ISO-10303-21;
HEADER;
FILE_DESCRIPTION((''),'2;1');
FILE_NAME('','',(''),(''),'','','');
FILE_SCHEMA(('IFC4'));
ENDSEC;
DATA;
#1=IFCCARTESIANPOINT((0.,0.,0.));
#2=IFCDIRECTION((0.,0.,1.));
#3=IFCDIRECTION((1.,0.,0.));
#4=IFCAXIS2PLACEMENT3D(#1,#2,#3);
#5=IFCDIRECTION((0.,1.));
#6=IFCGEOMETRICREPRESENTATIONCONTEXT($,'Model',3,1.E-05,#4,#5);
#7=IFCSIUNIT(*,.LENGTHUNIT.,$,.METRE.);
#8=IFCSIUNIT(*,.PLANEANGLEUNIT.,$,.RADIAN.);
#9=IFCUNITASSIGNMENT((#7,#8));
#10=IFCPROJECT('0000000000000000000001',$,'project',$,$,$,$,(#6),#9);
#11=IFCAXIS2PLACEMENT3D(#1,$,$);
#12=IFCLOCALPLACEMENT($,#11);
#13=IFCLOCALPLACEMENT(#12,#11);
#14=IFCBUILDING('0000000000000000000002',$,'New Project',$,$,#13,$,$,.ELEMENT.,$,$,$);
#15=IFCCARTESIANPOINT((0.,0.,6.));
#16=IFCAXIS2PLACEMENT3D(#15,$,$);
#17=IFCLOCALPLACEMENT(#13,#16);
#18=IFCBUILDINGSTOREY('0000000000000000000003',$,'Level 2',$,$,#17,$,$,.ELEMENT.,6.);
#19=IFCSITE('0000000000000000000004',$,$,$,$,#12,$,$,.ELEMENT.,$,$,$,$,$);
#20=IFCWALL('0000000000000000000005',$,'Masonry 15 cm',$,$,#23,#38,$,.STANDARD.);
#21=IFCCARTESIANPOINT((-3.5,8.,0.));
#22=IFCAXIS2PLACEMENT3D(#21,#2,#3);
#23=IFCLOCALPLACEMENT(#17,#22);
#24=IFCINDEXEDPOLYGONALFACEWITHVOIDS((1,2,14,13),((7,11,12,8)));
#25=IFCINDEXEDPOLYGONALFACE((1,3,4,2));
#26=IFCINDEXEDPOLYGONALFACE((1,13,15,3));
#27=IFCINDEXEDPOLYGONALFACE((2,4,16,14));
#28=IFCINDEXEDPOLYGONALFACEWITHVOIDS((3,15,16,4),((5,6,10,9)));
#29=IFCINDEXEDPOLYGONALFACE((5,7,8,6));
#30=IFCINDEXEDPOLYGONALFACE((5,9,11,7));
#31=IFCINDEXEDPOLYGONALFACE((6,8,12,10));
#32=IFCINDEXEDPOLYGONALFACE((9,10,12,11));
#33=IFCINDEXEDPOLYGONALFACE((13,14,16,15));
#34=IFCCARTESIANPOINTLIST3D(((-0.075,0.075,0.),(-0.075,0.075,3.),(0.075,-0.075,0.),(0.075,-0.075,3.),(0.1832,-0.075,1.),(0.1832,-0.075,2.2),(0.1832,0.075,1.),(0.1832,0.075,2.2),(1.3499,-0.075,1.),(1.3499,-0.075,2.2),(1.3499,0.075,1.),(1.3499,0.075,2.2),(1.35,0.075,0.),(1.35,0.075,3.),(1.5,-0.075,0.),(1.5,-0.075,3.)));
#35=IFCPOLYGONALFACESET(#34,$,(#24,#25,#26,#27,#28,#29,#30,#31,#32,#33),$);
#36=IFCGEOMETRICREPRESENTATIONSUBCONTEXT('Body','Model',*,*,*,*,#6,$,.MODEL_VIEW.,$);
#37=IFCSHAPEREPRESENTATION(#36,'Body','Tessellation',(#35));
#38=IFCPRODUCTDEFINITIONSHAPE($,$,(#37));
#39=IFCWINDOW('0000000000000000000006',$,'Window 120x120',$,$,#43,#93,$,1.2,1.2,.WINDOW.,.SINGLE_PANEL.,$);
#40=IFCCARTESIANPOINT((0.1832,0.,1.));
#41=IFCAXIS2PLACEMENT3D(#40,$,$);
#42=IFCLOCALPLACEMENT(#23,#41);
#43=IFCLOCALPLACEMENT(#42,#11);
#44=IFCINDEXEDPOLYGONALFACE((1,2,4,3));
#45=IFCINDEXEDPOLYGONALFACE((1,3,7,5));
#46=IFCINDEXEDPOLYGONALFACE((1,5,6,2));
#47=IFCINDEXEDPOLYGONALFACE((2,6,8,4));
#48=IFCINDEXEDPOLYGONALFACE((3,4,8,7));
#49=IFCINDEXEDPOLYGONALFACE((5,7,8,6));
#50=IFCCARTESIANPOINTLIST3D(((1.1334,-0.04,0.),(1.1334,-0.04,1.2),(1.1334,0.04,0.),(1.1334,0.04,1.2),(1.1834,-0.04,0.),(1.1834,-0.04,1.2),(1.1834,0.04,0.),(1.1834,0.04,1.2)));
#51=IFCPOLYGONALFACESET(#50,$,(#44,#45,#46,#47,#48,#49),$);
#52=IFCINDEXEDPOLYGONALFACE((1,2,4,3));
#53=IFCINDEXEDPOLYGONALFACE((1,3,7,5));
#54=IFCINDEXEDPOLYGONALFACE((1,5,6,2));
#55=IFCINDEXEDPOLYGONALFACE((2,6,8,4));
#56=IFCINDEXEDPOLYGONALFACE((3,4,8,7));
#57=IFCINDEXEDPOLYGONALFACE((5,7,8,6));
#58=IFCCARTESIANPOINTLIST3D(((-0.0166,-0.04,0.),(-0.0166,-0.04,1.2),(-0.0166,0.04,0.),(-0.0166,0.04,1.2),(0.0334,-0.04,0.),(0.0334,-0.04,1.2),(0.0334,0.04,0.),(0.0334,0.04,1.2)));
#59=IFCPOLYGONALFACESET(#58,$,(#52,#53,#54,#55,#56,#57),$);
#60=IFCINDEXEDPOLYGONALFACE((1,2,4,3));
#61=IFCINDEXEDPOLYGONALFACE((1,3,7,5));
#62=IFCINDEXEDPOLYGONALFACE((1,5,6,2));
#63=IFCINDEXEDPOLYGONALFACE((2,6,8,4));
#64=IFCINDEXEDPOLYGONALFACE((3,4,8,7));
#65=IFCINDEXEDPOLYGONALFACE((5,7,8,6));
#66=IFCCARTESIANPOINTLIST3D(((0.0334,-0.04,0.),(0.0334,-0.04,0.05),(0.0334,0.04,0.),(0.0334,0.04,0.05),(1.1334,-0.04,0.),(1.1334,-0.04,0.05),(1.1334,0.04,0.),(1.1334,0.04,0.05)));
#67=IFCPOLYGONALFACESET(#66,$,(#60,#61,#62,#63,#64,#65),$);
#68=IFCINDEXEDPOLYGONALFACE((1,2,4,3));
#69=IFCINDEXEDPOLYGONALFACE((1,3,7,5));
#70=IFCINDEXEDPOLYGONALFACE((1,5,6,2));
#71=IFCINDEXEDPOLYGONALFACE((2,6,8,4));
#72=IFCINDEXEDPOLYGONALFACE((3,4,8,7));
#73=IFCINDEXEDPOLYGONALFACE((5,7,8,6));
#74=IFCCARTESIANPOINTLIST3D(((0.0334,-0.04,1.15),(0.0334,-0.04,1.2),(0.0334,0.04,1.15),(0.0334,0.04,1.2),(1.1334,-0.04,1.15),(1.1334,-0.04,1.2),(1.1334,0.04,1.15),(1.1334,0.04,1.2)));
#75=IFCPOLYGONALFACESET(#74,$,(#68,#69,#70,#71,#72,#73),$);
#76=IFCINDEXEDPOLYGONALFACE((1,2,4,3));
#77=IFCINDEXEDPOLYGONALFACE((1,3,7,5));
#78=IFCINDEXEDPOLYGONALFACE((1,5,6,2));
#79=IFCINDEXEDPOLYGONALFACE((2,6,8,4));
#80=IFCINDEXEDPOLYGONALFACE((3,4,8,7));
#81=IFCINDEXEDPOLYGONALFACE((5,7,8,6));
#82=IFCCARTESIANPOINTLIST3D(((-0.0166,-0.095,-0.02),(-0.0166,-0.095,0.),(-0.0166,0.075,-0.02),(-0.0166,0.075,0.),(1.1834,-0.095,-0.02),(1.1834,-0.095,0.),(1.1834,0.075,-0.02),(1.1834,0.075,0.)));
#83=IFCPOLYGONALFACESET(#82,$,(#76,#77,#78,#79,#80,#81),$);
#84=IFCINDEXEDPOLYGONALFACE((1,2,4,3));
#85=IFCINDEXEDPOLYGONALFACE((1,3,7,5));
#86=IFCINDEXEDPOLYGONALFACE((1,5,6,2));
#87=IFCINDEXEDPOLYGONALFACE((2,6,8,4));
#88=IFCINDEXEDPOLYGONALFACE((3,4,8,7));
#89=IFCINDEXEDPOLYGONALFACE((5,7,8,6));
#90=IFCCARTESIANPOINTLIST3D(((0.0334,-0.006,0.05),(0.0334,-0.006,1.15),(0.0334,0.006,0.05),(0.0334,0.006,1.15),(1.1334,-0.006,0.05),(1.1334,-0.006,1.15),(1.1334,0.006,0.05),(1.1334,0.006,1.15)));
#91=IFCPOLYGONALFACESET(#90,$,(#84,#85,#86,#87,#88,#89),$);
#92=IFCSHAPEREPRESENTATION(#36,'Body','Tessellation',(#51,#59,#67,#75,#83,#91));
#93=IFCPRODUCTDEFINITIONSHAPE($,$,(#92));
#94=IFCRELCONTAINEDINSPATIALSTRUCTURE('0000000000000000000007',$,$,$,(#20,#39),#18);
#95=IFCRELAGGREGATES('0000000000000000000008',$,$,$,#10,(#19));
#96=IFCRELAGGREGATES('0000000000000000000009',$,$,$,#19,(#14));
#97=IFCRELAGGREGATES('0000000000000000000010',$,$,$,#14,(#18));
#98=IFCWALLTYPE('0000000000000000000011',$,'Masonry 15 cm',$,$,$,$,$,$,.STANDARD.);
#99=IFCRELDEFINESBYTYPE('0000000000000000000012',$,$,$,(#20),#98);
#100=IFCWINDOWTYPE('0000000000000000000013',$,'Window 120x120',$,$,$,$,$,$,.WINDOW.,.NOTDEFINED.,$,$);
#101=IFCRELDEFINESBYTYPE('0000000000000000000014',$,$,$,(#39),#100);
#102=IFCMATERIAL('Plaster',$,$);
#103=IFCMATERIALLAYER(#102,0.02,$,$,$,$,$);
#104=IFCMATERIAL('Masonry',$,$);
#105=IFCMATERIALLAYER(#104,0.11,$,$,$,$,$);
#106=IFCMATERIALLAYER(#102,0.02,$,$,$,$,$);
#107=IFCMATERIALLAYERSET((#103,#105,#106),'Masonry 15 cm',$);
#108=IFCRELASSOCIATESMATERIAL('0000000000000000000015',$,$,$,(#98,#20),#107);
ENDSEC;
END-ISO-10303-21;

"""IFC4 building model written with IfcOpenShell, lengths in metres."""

from ifc_helpers import new_model, si_unit, direction, frame, frame_2d, origin, origin_with_axes, place, context, subcontext, project, spatial, polyline, rectangle, outline, extrude, material, layer, layer_set, layer_usage, type_object, element, fill, save


model = new_model("IFC4")

# Units and contexts
model_context = context("Model", 3, precision=1e-05, world=origin_with_axes(), true_north=direction((0.0, 1.0)))
body_context = subcontext(model_context, "Body", "Model", "MODEL_VIEW")
ifc_project = project(units=[si_unit("LENGTHUNIT", "METRE"), si_unit("PLANEANGLEUNIT", "RADIAN")], contexts=[model_context])

# Site, building, storey
site_placement = place(None, origin())
site = spatial("IfcSite", under=ifc_project, at=site_placement, CompositionType="ELEMENT")
building_placement = place(site_placement, origin())
building = spatial("IfcBuilding", under=site, at=building_placement, Name="New Project", CompositionType="ELEMENT")
storey_placement = place(building_placement, frame((0.0, 0.0, 6.0)))
storey = spatial("IfcBuildingStorey", under=building, at=storey_placement, Name="Level 2", CompositionType="ELEMENT", Elevation=6.0)

# Shared definitions
ifc_material_1 = material(Name="Plaster")
ifc_layer_1 = layer(ifc_material_1, 0.02)
ifc_material_2 = material(Name="Masonry")
ifc_layer_2 = layer(ifc_material_2, 0.11)
ifc_layer_3 = layer(ifc_material_1, 0.02)
ifc_layer_set_1 = layer_set([ifc_layer_1, ifc_layer_2, ifc_layer_3], Name="Masonry 15 cm")
ifc_layer_usage_1 = layer_usage(ifc_layer_set_1, "AXIS2", "NEGATIVE", 0.075)
wall_type = type_object("IfcWallType", Name="Masonry 15 cm", PredefinedType="STANDARD", material=ifc_layer_set_1)
window_type = type_object("IfcWindowType", Name="Window 120x120", PartitioningType="NOTDEFINED", PredefinedType="WINDOW")

# Wall, opening, window
wall_1_placement = place(storey_placement, frame((-3.5, 8.0, 0.0), z_axis=(0.0, 0.0, 1.0), x_axis=(1.0, 0.0, 0.0)))
wall_1 = element("IfcWall", 1, at=wall_1_placement, inside=storey, type_object=wall_type, material=ifc_layer_usage_1, Name="Masonry 15 cm", PredefinedType="STANDARD", context=body_context, shape_type="SweptSolid", body=[
    extrude(outline(polyline([(0.075, -0.075), (1.5, -0.075), (1.35, 0.075), (-0.075, 0.075), (0.075, -0.075)])), origin(), (0.0, 0.0, 1.0), 3.0),
])
opening_1_placement = place(wall_1_placement, frame((0.1832, 0.0, 1.0)))
opening_1 = element("IfcOpeningElement", 2, at=opening_1_placement, cuts=wall_1, PredefinedType="OPENING", context=body_context, shape_type="SweptSolid", body=[
    extrude(rectangle(XDim=1.1667, YDim=0.25, at=frame_2d((0.5834, 0.0))), origin(), (0.0, 0.0, 1.0), 1.2),
])
window_1_placement = place(opening_1_placement, origin())
window_1 = element("IfcWindow", 3, at=window_1_placement, inside=storey, type_object=window_type, Name="Window 120x120", OverallHeight=1.2, OverallWidth=1.2, PartitioningType="SINGLE_PANEL", PredefinedType="WINDOW", context=body_context, shape_type="SweptSolid", body=[
    extrude(outline(polyline([(1.1834, 0.04), (1.1334, 0.04), (1.1334, -0.04), (1.1834, -0.04), (1.1834, 0.04)])), origin(), (0.0, 0.0, 1.0), 1.2),
    extrude(outline(polyline([(0.0334, 0.04), (-0.0166, 0.04), (-0.0166, -0.04), (0.0334, -0.04), (0.0334, 0.04)])), origin(), (0.0, 0.0, 1.0), 1.2),
    extrude(outline(polyline([(1.1334, 0.04), (0.0334, 0.04), (0.0334, -0.04), (1.1334, -0.04), (1.1334, 0.04)])), origin(), (0.0, 0.0, 1.0), 0.05),
    extrude(outline(polyline([(1.1334, 0.04), (0.0334, 0.04), (0.0334, -0.04), (1.1334, -0.04), (1.1334, 0.04)])), frame((0.0, 0.0, 1.15)), (0.0, 0.0, 1.0), 0.05),
    extrude(outline(polyline([(1.1834, 0.075), (-0.0166, 0.075), (-0.0166, -0.095), (1.1834, -0.095), (1.1834, 0.075)])), frame((0.0, 0.0, -0.02)), (0.0, 0.0, 1.0), 0.02),
    extrude(outline(polyline([(1.1334, 0.006), (0.0334, 0.006), (0.0334, -0.006), (1.1334, -0.006), (1.1334, 0.006)])), frame((0.0, 0.0, 0.05)), (0.0, 0.0, 1.0), 1.1),
])
fill(opening_1, window_1)

save(model, "model.ifc")
